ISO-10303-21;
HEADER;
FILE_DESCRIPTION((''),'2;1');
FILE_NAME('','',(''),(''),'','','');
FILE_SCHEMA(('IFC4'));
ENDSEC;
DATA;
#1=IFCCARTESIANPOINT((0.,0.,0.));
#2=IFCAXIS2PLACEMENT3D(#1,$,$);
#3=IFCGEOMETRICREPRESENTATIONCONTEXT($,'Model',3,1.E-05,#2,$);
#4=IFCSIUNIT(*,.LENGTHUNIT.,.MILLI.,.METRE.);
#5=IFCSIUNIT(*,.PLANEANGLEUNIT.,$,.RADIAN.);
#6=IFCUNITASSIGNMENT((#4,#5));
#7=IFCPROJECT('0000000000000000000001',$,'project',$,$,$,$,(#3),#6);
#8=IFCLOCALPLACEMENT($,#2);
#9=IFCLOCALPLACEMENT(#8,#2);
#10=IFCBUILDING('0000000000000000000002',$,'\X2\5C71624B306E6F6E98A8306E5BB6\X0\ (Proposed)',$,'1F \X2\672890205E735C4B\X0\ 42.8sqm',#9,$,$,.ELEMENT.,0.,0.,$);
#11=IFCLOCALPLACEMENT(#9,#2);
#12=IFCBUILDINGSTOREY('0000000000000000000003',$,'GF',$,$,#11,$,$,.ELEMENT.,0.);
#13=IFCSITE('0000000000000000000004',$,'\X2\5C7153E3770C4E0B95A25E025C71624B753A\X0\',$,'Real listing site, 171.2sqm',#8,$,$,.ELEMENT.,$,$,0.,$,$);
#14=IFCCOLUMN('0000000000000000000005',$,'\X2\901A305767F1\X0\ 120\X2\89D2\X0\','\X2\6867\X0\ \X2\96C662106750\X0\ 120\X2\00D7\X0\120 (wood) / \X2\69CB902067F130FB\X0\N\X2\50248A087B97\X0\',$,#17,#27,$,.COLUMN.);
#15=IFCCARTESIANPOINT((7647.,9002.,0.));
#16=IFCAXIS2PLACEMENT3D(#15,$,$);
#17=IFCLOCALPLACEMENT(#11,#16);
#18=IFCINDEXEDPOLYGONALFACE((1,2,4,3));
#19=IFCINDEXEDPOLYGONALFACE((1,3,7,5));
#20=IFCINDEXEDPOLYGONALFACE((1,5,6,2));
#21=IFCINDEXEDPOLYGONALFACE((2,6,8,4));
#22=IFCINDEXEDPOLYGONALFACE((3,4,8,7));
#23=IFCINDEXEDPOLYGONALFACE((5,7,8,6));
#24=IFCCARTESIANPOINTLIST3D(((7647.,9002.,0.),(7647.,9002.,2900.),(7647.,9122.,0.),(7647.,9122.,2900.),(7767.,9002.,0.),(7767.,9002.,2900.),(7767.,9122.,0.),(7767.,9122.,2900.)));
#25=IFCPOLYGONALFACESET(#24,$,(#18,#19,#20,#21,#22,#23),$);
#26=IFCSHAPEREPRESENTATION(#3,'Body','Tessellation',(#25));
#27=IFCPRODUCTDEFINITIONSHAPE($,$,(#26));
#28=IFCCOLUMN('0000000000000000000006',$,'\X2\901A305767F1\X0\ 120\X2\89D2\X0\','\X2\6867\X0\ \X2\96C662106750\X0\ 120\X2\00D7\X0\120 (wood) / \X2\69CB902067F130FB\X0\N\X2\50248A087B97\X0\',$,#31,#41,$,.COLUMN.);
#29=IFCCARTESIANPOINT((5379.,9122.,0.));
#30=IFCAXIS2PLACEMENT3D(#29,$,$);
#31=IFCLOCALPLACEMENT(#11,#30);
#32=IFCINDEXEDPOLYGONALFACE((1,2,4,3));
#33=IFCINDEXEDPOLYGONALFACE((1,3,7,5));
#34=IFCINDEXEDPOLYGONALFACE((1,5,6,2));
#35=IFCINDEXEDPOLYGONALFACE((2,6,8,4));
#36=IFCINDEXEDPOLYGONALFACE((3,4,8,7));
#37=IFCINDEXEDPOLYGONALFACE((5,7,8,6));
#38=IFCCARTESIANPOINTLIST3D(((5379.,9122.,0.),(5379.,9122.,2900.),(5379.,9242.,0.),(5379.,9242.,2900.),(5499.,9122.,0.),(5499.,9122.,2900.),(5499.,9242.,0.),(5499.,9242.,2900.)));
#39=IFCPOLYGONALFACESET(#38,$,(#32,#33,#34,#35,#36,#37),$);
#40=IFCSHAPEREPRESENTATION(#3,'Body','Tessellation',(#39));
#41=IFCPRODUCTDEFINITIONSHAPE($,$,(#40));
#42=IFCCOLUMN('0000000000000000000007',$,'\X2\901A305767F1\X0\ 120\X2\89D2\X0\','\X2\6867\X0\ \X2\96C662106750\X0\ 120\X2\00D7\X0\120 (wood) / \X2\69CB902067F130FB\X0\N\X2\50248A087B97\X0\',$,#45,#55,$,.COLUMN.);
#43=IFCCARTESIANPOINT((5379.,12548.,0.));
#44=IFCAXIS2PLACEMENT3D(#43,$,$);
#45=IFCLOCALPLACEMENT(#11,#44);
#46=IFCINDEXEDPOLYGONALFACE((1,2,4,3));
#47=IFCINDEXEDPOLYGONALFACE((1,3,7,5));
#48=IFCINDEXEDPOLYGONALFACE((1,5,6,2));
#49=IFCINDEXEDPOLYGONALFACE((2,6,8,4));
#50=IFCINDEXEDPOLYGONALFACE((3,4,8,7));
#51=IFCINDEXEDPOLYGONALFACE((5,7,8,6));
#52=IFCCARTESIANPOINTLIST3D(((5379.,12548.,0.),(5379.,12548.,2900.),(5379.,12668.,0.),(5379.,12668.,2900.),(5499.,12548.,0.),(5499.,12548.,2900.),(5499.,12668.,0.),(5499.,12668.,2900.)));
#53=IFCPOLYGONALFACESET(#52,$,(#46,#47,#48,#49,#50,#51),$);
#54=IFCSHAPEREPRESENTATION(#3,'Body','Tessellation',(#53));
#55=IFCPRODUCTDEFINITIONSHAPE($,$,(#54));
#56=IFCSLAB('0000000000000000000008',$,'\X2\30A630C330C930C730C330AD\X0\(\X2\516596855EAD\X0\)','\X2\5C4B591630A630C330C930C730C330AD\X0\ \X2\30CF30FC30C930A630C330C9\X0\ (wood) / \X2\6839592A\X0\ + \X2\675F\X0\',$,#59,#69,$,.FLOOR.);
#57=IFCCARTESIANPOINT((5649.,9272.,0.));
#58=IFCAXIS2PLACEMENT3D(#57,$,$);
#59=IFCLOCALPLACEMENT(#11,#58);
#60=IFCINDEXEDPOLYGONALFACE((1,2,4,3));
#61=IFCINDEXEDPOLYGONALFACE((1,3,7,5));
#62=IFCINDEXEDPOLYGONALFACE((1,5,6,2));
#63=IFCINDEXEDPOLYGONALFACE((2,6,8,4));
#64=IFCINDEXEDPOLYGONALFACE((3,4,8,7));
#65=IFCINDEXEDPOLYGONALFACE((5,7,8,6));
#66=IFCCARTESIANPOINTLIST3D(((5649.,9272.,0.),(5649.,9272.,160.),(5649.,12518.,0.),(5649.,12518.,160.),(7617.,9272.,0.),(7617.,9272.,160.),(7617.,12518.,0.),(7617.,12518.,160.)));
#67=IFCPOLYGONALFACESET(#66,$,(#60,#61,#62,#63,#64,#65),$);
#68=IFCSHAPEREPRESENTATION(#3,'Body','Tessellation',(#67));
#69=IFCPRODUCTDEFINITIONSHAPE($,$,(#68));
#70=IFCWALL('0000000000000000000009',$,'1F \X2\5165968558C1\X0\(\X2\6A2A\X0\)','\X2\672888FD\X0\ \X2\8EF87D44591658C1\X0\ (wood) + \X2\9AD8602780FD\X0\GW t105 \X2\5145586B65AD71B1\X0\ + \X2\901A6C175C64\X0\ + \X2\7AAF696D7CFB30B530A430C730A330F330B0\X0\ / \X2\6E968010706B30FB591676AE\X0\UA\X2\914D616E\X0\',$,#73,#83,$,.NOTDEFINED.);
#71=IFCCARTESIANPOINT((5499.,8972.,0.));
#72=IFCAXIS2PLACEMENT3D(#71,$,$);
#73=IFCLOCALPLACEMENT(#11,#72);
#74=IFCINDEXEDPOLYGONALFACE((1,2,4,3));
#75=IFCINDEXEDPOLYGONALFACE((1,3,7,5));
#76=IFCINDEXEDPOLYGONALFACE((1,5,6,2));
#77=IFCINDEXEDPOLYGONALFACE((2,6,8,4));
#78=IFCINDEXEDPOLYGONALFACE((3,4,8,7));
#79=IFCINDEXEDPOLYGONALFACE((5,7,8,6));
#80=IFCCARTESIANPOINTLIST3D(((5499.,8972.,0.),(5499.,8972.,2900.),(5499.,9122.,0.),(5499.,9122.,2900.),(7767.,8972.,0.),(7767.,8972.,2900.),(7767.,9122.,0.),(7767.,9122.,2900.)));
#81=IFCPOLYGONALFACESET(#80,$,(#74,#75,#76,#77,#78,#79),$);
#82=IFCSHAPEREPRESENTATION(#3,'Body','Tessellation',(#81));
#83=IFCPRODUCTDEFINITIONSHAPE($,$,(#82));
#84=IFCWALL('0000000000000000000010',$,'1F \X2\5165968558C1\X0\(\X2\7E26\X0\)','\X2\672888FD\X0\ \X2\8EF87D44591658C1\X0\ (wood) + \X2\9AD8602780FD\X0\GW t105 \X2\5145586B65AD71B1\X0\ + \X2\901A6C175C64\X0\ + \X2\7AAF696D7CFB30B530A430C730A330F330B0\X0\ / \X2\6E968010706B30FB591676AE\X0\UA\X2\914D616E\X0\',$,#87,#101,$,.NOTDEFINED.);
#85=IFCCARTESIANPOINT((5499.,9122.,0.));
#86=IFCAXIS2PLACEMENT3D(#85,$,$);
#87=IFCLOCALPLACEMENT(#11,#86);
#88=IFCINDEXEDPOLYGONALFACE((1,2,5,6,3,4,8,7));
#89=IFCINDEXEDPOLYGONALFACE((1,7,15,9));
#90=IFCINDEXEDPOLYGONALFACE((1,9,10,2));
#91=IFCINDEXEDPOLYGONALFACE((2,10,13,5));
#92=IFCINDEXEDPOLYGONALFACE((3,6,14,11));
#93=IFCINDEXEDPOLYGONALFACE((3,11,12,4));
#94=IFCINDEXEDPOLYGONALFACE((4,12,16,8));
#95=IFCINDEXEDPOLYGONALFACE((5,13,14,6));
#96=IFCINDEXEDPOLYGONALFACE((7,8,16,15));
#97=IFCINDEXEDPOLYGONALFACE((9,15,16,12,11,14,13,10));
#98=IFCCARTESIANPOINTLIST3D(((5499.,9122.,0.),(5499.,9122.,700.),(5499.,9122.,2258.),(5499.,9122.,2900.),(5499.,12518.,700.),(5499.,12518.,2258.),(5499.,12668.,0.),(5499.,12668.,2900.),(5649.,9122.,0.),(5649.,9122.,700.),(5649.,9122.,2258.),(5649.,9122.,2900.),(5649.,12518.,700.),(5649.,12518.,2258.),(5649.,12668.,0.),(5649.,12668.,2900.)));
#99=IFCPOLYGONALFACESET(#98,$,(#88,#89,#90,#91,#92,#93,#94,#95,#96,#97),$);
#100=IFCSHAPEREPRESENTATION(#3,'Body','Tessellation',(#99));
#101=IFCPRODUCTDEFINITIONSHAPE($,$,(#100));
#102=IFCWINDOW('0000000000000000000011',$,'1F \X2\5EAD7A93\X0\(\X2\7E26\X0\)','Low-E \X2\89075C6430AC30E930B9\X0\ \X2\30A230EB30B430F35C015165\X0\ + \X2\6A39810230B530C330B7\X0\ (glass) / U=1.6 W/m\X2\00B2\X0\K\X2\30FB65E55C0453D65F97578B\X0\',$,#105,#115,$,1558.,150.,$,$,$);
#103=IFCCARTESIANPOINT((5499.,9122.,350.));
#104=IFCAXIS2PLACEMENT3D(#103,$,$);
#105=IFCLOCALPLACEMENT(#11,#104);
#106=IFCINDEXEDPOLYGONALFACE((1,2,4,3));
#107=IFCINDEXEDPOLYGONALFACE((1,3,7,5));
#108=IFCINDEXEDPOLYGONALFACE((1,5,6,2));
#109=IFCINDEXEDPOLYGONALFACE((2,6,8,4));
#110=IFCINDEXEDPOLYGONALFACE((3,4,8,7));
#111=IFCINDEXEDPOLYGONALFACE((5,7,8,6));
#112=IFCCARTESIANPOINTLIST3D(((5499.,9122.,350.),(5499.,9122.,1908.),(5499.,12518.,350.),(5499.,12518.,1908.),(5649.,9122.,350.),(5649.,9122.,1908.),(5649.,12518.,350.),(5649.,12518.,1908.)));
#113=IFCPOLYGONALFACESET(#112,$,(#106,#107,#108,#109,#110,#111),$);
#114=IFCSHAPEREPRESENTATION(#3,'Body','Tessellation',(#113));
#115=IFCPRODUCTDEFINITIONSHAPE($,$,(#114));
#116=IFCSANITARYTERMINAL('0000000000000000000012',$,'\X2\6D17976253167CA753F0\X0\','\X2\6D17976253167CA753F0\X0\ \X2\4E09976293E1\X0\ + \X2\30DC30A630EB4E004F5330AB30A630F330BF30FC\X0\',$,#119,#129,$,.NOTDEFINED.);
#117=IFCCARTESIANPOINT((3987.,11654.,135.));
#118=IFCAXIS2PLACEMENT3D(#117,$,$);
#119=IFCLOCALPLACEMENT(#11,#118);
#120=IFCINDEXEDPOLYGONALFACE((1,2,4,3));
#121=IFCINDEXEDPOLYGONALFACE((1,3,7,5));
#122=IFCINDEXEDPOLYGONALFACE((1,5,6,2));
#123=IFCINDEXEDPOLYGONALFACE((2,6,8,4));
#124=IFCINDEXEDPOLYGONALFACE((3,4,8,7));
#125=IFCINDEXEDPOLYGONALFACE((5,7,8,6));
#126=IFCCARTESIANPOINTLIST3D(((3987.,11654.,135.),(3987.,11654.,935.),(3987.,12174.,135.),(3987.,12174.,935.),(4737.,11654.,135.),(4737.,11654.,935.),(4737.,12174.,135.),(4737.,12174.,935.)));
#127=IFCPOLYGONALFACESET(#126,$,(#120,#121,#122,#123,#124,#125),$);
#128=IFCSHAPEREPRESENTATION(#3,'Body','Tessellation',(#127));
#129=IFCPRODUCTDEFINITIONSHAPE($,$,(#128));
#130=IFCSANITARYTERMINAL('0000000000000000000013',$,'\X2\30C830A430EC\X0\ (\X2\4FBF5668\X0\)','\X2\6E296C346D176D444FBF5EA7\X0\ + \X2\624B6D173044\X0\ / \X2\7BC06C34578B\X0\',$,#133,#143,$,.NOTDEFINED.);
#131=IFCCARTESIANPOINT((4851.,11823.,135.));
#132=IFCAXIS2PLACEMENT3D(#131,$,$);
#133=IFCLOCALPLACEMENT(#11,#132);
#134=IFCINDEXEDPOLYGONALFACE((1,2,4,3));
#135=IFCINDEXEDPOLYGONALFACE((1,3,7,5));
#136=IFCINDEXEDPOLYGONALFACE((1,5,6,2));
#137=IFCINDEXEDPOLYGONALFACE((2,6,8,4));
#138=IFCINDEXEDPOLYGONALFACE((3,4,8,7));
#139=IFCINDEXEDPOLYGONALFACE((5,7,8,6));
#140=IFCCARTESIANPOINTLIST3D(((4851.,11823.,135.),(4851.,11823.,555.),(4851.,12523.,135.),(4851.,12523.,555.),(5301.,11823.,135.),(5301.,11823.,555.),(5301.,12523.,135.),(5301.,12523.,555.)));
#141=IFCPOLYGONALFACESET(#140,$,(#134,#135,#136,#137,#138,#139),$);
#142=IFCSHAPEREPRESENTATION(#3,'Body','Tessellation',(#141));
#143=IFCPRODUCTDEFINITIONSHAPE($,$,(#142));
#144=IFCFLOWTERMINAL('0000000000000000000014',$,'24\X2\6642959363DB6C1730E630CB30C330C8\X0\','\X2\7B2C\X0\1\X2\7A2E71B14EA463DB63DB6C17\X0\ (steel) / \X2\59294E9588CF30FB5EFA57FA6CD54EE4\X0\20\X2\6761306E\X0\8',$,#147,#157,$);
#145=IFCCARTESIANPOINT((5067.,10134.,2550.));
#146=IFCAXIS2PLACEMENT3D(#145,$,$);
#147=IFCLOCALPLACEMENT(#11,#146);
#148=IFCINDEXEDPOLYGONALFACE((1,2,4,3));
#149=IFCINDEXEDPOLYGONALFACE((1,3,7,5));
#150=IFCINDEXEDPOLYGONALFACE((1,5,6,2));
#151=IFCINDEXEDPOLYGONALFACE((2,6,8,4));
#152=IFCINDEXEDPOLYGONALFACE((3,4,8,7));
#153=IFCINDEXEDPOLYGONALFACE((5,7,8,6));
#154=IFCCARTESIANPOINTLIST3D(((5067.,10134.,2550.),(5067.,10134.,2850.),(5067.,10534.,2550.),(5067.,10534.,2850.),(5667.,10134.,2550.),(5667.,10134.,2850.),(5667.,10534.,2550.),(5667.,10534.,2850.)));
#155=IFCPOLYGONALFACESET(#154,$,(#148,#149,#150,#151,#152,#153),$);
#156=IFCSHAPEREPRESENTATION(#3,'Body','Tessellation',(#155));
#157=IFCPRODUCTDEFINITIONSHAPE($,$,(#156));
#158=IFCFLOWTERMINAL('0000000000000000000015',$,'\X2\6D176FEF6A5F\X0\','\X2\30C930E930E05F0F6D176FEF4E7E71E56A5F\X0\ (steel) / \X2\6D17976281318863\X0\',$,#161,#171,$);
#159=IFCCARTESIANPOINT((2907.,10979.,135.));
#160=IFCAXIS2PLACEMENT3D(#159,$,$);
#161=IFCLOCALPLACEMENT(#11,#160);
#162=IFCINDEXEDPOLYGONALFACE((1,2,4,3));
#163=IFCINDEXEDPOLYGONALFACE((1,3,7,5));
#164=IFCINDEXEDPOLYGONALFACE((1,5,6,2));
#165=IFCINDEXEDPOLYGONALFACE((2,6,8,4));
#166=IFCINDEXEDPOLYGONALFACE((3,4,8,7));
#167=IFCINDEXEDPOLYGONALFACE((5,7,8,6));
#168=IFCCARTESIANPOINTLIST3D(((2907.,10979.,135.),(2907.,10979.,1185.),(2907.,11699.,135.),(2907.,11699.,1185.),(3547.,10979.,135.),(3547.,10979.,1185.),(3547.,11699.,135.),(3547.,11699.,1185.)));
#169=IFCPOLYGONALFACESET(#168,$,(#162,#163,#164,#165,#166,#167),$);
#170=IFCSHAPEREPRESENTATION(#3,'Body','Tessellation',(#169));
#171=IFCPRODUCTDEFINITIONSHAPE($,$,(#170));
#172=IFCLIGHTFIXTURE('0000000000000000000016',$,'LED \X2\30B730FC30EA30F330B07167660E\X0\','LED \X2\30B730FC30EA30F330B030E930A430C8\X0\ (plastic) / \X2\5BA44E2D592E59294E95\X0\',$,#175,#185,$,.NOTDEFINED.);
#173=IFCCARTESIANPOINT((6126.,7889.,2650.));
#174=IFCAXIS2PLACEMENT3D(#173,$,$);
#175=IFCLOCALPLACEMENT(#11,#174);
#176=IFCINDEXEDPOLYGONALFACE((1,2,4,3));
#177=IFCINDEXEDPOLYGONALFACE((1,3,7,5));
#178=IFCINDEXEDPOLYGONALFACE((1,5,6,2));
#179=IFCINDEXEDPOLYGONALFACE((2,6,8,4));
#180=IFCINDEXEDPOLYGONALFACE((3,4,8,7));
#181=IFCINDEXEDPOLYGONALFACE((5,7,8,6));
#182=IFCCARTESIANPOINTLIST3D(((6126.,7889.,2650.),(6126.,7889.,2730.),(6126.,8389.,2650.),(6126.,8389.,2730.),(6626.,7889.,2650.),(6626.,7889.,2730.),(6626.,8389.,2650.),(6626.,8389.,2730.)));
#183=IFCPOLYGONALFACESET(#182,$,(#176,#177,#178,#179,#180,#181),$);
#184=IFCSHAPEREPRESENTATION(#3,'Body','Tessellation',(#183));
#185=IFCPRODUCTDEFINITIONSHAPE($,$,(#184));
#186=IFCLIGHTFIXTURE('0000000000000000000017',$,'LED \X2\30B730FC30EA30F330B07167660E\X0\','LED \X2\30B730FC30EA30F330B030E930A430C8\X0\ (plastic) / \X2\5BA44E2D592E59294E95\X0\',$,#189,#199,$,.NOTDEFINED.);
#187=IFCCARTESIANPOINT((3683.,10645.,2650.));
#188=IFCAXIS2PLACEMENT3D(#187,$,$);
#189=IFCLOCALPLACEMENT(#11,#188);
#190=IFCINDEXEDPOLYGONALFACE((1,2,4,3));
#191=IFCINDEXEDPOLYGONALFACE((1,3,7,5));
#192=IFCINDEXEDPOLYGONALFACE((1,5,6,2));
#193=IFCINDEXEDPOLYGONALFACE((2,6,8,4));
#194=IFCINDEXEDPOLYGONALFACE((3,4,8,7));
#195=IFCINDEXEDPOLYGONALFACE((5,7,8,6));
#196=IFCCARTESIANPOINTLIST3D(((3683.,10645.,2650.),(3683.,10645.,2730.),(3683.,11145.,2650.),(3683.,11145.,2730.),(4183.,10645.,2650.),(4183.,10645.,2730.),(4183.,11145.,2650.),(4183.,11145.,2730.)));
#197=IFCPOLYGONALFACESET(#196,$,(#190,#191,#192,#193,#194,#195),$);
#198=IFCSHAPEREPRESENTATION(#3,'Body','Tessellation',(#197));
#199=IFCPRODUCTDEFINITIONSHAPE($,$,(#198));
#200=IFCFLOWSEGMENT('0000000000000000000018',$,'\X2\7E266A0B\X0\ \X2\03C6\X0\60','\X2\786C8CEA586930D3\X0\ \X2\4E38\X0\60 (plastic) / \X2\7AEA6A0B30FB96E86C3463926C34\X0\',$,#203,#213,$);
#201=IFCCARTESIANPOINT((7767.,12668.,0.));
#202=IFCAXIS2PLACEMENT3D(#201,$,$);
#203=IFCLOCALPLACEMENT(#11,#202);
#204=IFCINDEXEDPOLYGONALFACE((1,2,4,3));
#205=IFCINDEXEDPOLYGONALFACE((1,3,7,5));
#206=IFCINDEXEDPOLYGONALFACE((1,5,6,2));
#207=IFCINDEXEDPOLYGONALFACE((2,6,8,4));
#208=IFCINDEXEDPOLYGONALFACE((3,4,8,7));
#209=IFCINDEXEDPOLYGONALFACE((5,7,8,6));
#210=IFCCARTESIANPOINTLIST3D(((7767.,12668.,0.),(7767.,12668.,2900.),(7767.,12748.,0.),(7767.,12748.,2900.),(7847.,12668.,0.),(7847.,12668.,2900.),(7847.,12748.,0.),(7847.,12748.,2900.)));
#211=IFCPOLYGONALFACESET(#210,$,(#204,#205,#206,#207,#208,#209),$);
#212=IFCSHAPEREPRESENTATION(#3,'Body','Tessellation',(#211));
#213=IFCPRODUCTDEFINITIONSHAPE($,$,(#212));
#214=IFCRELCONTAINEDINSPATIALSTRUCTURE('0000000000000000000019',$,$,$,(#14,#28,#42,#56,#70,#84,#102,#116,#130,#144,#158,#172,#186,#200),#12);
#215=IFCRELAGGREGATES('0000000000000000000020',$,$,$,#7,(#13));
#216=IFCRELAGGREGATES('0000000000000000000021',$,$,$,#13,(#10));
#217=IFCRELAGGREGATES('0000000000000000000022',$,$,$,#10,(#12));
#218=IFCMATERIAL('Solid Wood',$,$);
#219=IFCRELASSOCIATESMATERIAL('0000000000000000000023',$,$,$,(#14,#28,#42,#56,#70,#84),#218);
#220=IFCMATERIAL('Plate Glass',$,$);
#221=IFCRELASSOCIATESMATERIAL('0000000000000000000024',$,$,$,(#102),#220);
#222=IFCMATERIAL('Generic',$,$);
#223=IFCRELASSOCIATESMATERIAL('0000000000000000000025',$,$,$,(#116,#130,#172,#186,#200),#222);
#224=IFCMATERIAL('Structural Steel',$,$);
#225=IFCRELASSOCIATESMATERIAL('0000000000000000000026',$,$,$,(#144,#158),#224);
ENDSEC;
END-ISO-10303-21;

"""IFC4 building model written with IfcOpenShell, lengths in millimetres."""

from ifc_helpers import new_model, si_unit, frame, frame_2d, origin, place, context, project, spatial, rectangle, extrude, material, element, fill, save


model = new_model("IFC4")

# Units and contexts
model_context = context("Model", 3, precision=1e-05, world=origin())
ifc_project = project(units=[si_unit("LENGTHUNIT", "METRE", prefix="MILLI"), si_unit("PLANEANGLEUNIT", "RADIAN")], contexts=[model_context])

# Site, building, storey
site_placement = place(None, origin())
site = spatial("IfcSite", under=ifc_project, at=site_placement, Name="山口県下関市山手町", ObjectType="Real listing site, 171.2sqm", CompositionType="ELEMENT", RefElevation=0.0)
building_placement = place(site_placement, origin())
building = spatial("IfcBuilding", under=site, at=building_placement, Name="山手の潮風の家 (Proposed)", ObjectType="1F 木造平屋 42.8sqm", CompositionType="ELEMENT", ElevationOfRefHeight=0.0, ElevationOfTerrain=0.0)
storey_placement = place(building_placement, origin())
storey = spatial("IfcBuildingStorey", under=building, at=storey_placement, Name="GF", CompositionType="ELEMENT", Elevation=0.0)

# Columns
ifc_material_1 = material(Name="Solid Wood")
column_1_placement = place(storey_placement, frame((7647.0, 9002.0, 0.0)))
element("IfcColumn", 1, at=column_1_placement, inside=storey, material=ifc_material_1, Name="通し柱 120角", Description="桧 集成材 120×120 (wood) / 構造柱・N値計算", PredefinedType="COLUMN", context=model_context, shape_type="SweptSolid", body=[
    extrude(rectangle(XDim=120.0, YDim=120.0, at=frame_2d((60.0, 60.0))), frame((7647.0, 9002.0, 0.0)), (0.0, 0.0, 1.0), 2900.0),
])
column_2_placement = place(storey_placement, frame((5379.0, 9122.0, 0.0)))
element("IfcColumn", 2, at=column_2_placement, inside=storey, material=ifc_material_1, Name="通し柱 120角", Description="桧 集成材 120×120 (wood) / 構造柱・N値計算", PredefinedType="COLUMN", context=model_context, shape_type="SweptSolid", body=[
    extrude(rectangle(XDim=120.0, YDim=120.0, at=frame_2d((60.0, 60.0))), frame((5379.0, 9122.0, 0.0)), (0.0, 0.0, 1.0), 2900.0),
])
column_3_placement = place(storey_placement, frame((5379.0, 12548.0, 0.0)))
element("IfcColumn", 3, at=column_3_placement, inside=storey, material=ifc_material_1, Name="通し柱 120角", Description="桧 集成材 120×120 (wood) / 構造柱・N値計算", PredefinedType="COLUMN", context=model_context, shape_type="SweptSolid", body=[
    extrude(rectangle(XDim=120.0, YDim=120.0, at=frame_2d((60.0, 60.0))), frame((5379.0, 12548.0, 0.0)), (0.0, 0.0, 1.0), 2900.0),
])

# Slab
slab_placement = place(storey_placement, frame((5649.0, 9272.0, 0.0)))
element("IfcSlab", 4, at=slab_placement, inside=storey, material=ifc_material_1, Name="ウッドデッキ(入隅庭)", Description="屋外ウッドデッキ ハードウッド (wood) / 根太 + 束", PredefinedType="FLOOR", context=model_context, shape_type="SweptSolid", body=[
    extrude(rectangle(XDim=1968.0, YDim=3246.0, at=frame_2d((984.0, 1623.0))), frame((5649.0, 9272.0, 0.0)), (0.0, 0.0, 1.0), 160.0),
])

# Wall
wall_1_placement = place(storey_placement, frame((5499.0, 8972.0, 0.0)))
element("IfcWall", 5, at=wall_1_placement, inside=storey, material=ifc_material_1, Name="1F 入隅壁(横)", Description="木製 軸組外壁 (wood) + 高性能GW t105 充填断熱 + 通気層 + 窯業系サイディング / 準耐火・外皮UA配慮", PredefinedType="NOTDEFINED", context=model_context, shape_type="SweptSolid", body=[
    extrude(rectangle(XDim=2268.0, YDim=150.0, at=frame_2d((1134.0, 75.0))), frame((5499.0, 8972.0, 0.0)), (0.0, 0.0, 1.0), 2900.0),
])

# Wall, opening, window
wall_2_placement = place(storey_placement, frame((5499.0, 9122.0, 0.0)))
wall_2 = element("IfcWall", 6, at=wall_2_placement, inside=storey, material=ifc_material_1, Name="1F 入隅壁(縦)", Description="木製 軸組外壁 (wood) + 高性能GW t105 充填断熱 + 通気層 + 窯業系サイディング / 準耐火・外皮UA配慮", PredefinedType="NOTDEFINED", context=model_context, shape_type="SweptSolid", body=[
    extrude(rectangle(XDim=150.0, YDim=3546.0, at=frame_2d((75.0, 1773.0))), frame((5499.0, 9122.0, 0.0)), (0.0, 0.0, 1.0), 2900.0),
])
opening_placement = place(storey_placement, frame((5499.0, 9122.0, 350.0)))
opening = element("IfcOpeningElement", 7, at=opening_placement, cuts=wall_2, PredefinedType="NOTDEFINED", context=model_context, shape_type="SweptSolid", body=[
    extrude(rectangle(XDim=150.0, YDim=3396.0, at=frame_2d((75.0, 1698.0))), frame((5499.0, 9122.0, 350.0)), (0.0, 0.0, 1.0), 1558.0),
])
ifc_material_2 = material(Name="Plate Glass")
window_placement = place(storey_placement, frame((5499.0, 9122.0, 350.0)))
window = element("IfcWindow", 8, at=window_placement, inside=storey, material=ifc_material_2, Name="1F 庭窓(縦)", Description="Low-E 複層ガラス アルゴン封入 + 樹脂サッシ (glass) / U=1.6 W/m²K・日射取得型", OverallHeight=1558.0, OverallWidth=150.0, context=model_context, shape_type="SweptSolid", body=[
    extrude(rectangle(XDim=150.0, YDim=3396.0, at=frame_2d((75.0, 1698.0))), frame((5499.0, 9122.0, 350.0)), (0.0, 0.0, 1.0), 1558.0),
])
fill(opening, window)

# Sanitary terminals
ifc_material_3 = material(Name="Generic")
sanitary_terminal_1_placement = place(storey_placement, frame((3987.0, 11654.0, 135.0)))
element("IfcSanitaryTerminal", 9, at=sanitary_terminal_1_placement, inside=storey, material=ifc_material_3, Name="洗面化粧台", Description="洗面化粧台 三面鏡 + ボウル一体カウンター", PredefinedType="NOTDEFINED", context=model_context, shape_type="SweptSolid", body=[
    extrude(rectangle(XDim=750.0, YDim=520.0, at=frame_2d((375.0, 260.0))), frame((3987.0, 11654.0, 135.0)), (0.0, 0.0, 1.0), 800.0),
])
sanitary_terminal_2_placement = place(storey_placement, frame((4851.0, 11823.0, 135.0)))
element("IfcSanitaryTerminal", 10, at=sanitary_terminal_2_placement, inside=storey, material=ifc_material_3, Name="トイレ (便器)", Description="温水洗浄便座 + 手洗い / 節水型", PredefinedType="NOTDEFINED", context=model_context, shape_type="SweptSolid", body=[
    extrude(rectangle(XDim=450.0, YDim=700.0, at=frame_2d((225.0, 350.0))), frame((4851.0, 11823.0, 135.0)), (0.0, 0.0, 1.0), 420.0),
])

# Flow terminals
ifc_material_4 = material(Name="Structural Steel")
flow_terminal_1_placement = place(storey_placement, frame((5067.0, 10134.0, 2550.0)))
element("IfcFlowTerminal", 11, at=flow_terminal_1_placement, inside=storey, material=ifc_material_4, Name="24時間換気ユニット", Description="第1種熱交換換気 (steel) / 天井裏・建基法令20条の8", context=model_context, shape_type="SweptSolid", body=[
    extrude(rectangle(XDim=600.0, YDim=400.0, at=frame_2d((300.0, 200.0))), frame((5067.0, 10134.0, 2550.0)), (0.0, 0.0, 1.0), 300.0),
])
flow_terminal_2_placement = place(storey_placement, frame((2907.0, 10979.0, 135.0)))
element("IfcFlowTerminal", 12, at=flow_terminal_2_placement, inside=storey, material=ifc_material_4, Name="洗濯機", Description="ドラム式洗濯乾燥機 (steel) / 洗面脱衣", context=model_context, shape_type="SweptSolid", body=[
    extrude(rectangle(XDim=640.0, YDim=720.0, at=frame_2d((320.0, 360.0))), frame((2907.0, 10979.0, 135.0)), (0.0, 0.0, 1.0), 1050.0),
])

# Light fixtures
light_fixture_1_placement = place(storey_placement, frame((6126.0, 7889.0, 2650.0)))
element("IfcLightFixture", 13, at=light_fixture_1_placement, inside=storey, material=ifc_material_3, Name="LED シーリング照明", Description="LED シーリングライト (plastic) / 室中央天井", PredefinedType="NOTDEFINED", context=model_context, shape_type="SweptSolid", body=[
    extrude(rectangle(XDim=500.0, YDim=500.0, at=frame_2d((250.0, 250.0))), frame((6126.0, 7889.0, 2650.0)), (0.0, 0.0, 1.0), 80.0),
])
light_fixture_2_placement = place(storey_placement, frame((3683.0, 10645.0, 2650.0)))
element("IfcLightFixture", 14, at=light_fixture_2_placement, inside=storey, material=ifc_material_3, Name="LED シーリング照明", Description="LED シーリングライト (plastic) / 室中央天井", PredefinedType="NOTDEFINED", context=model_context, shape_type="SweptSolid", body=[
    extrude(rectangle(XDim=500.0, YDim=500.0, at=frame_2d((250.0, 250.0))), frame((3683.0, 10645.0, 2650.0)), (0.0, 0.0, 1.0), 80.0),
])

# Flow segment
flow_segment_placement = place(storey_placement, frame((7767.0, 12668.0, 0.0)))
element("IfcFlowSegment", 15, at=flow_segment_placement, inside=storey, material=ifc_material_3, Name="縦樋 φ60", Description="硬質塩ビ 丸60 (plastic) / 竪樋・雨水排水", context=model_context, shape_type="SweptSolid", body=[
    extrude(rectangle(XDim=80.0, YDim=80.0, at=frame_2d((40.0, 40.0))), frame((7767.0, 12668.0, 0.0)), (0.0, 0.0, 1.0), 2900.0),
])

save(model, "model.ifc")
